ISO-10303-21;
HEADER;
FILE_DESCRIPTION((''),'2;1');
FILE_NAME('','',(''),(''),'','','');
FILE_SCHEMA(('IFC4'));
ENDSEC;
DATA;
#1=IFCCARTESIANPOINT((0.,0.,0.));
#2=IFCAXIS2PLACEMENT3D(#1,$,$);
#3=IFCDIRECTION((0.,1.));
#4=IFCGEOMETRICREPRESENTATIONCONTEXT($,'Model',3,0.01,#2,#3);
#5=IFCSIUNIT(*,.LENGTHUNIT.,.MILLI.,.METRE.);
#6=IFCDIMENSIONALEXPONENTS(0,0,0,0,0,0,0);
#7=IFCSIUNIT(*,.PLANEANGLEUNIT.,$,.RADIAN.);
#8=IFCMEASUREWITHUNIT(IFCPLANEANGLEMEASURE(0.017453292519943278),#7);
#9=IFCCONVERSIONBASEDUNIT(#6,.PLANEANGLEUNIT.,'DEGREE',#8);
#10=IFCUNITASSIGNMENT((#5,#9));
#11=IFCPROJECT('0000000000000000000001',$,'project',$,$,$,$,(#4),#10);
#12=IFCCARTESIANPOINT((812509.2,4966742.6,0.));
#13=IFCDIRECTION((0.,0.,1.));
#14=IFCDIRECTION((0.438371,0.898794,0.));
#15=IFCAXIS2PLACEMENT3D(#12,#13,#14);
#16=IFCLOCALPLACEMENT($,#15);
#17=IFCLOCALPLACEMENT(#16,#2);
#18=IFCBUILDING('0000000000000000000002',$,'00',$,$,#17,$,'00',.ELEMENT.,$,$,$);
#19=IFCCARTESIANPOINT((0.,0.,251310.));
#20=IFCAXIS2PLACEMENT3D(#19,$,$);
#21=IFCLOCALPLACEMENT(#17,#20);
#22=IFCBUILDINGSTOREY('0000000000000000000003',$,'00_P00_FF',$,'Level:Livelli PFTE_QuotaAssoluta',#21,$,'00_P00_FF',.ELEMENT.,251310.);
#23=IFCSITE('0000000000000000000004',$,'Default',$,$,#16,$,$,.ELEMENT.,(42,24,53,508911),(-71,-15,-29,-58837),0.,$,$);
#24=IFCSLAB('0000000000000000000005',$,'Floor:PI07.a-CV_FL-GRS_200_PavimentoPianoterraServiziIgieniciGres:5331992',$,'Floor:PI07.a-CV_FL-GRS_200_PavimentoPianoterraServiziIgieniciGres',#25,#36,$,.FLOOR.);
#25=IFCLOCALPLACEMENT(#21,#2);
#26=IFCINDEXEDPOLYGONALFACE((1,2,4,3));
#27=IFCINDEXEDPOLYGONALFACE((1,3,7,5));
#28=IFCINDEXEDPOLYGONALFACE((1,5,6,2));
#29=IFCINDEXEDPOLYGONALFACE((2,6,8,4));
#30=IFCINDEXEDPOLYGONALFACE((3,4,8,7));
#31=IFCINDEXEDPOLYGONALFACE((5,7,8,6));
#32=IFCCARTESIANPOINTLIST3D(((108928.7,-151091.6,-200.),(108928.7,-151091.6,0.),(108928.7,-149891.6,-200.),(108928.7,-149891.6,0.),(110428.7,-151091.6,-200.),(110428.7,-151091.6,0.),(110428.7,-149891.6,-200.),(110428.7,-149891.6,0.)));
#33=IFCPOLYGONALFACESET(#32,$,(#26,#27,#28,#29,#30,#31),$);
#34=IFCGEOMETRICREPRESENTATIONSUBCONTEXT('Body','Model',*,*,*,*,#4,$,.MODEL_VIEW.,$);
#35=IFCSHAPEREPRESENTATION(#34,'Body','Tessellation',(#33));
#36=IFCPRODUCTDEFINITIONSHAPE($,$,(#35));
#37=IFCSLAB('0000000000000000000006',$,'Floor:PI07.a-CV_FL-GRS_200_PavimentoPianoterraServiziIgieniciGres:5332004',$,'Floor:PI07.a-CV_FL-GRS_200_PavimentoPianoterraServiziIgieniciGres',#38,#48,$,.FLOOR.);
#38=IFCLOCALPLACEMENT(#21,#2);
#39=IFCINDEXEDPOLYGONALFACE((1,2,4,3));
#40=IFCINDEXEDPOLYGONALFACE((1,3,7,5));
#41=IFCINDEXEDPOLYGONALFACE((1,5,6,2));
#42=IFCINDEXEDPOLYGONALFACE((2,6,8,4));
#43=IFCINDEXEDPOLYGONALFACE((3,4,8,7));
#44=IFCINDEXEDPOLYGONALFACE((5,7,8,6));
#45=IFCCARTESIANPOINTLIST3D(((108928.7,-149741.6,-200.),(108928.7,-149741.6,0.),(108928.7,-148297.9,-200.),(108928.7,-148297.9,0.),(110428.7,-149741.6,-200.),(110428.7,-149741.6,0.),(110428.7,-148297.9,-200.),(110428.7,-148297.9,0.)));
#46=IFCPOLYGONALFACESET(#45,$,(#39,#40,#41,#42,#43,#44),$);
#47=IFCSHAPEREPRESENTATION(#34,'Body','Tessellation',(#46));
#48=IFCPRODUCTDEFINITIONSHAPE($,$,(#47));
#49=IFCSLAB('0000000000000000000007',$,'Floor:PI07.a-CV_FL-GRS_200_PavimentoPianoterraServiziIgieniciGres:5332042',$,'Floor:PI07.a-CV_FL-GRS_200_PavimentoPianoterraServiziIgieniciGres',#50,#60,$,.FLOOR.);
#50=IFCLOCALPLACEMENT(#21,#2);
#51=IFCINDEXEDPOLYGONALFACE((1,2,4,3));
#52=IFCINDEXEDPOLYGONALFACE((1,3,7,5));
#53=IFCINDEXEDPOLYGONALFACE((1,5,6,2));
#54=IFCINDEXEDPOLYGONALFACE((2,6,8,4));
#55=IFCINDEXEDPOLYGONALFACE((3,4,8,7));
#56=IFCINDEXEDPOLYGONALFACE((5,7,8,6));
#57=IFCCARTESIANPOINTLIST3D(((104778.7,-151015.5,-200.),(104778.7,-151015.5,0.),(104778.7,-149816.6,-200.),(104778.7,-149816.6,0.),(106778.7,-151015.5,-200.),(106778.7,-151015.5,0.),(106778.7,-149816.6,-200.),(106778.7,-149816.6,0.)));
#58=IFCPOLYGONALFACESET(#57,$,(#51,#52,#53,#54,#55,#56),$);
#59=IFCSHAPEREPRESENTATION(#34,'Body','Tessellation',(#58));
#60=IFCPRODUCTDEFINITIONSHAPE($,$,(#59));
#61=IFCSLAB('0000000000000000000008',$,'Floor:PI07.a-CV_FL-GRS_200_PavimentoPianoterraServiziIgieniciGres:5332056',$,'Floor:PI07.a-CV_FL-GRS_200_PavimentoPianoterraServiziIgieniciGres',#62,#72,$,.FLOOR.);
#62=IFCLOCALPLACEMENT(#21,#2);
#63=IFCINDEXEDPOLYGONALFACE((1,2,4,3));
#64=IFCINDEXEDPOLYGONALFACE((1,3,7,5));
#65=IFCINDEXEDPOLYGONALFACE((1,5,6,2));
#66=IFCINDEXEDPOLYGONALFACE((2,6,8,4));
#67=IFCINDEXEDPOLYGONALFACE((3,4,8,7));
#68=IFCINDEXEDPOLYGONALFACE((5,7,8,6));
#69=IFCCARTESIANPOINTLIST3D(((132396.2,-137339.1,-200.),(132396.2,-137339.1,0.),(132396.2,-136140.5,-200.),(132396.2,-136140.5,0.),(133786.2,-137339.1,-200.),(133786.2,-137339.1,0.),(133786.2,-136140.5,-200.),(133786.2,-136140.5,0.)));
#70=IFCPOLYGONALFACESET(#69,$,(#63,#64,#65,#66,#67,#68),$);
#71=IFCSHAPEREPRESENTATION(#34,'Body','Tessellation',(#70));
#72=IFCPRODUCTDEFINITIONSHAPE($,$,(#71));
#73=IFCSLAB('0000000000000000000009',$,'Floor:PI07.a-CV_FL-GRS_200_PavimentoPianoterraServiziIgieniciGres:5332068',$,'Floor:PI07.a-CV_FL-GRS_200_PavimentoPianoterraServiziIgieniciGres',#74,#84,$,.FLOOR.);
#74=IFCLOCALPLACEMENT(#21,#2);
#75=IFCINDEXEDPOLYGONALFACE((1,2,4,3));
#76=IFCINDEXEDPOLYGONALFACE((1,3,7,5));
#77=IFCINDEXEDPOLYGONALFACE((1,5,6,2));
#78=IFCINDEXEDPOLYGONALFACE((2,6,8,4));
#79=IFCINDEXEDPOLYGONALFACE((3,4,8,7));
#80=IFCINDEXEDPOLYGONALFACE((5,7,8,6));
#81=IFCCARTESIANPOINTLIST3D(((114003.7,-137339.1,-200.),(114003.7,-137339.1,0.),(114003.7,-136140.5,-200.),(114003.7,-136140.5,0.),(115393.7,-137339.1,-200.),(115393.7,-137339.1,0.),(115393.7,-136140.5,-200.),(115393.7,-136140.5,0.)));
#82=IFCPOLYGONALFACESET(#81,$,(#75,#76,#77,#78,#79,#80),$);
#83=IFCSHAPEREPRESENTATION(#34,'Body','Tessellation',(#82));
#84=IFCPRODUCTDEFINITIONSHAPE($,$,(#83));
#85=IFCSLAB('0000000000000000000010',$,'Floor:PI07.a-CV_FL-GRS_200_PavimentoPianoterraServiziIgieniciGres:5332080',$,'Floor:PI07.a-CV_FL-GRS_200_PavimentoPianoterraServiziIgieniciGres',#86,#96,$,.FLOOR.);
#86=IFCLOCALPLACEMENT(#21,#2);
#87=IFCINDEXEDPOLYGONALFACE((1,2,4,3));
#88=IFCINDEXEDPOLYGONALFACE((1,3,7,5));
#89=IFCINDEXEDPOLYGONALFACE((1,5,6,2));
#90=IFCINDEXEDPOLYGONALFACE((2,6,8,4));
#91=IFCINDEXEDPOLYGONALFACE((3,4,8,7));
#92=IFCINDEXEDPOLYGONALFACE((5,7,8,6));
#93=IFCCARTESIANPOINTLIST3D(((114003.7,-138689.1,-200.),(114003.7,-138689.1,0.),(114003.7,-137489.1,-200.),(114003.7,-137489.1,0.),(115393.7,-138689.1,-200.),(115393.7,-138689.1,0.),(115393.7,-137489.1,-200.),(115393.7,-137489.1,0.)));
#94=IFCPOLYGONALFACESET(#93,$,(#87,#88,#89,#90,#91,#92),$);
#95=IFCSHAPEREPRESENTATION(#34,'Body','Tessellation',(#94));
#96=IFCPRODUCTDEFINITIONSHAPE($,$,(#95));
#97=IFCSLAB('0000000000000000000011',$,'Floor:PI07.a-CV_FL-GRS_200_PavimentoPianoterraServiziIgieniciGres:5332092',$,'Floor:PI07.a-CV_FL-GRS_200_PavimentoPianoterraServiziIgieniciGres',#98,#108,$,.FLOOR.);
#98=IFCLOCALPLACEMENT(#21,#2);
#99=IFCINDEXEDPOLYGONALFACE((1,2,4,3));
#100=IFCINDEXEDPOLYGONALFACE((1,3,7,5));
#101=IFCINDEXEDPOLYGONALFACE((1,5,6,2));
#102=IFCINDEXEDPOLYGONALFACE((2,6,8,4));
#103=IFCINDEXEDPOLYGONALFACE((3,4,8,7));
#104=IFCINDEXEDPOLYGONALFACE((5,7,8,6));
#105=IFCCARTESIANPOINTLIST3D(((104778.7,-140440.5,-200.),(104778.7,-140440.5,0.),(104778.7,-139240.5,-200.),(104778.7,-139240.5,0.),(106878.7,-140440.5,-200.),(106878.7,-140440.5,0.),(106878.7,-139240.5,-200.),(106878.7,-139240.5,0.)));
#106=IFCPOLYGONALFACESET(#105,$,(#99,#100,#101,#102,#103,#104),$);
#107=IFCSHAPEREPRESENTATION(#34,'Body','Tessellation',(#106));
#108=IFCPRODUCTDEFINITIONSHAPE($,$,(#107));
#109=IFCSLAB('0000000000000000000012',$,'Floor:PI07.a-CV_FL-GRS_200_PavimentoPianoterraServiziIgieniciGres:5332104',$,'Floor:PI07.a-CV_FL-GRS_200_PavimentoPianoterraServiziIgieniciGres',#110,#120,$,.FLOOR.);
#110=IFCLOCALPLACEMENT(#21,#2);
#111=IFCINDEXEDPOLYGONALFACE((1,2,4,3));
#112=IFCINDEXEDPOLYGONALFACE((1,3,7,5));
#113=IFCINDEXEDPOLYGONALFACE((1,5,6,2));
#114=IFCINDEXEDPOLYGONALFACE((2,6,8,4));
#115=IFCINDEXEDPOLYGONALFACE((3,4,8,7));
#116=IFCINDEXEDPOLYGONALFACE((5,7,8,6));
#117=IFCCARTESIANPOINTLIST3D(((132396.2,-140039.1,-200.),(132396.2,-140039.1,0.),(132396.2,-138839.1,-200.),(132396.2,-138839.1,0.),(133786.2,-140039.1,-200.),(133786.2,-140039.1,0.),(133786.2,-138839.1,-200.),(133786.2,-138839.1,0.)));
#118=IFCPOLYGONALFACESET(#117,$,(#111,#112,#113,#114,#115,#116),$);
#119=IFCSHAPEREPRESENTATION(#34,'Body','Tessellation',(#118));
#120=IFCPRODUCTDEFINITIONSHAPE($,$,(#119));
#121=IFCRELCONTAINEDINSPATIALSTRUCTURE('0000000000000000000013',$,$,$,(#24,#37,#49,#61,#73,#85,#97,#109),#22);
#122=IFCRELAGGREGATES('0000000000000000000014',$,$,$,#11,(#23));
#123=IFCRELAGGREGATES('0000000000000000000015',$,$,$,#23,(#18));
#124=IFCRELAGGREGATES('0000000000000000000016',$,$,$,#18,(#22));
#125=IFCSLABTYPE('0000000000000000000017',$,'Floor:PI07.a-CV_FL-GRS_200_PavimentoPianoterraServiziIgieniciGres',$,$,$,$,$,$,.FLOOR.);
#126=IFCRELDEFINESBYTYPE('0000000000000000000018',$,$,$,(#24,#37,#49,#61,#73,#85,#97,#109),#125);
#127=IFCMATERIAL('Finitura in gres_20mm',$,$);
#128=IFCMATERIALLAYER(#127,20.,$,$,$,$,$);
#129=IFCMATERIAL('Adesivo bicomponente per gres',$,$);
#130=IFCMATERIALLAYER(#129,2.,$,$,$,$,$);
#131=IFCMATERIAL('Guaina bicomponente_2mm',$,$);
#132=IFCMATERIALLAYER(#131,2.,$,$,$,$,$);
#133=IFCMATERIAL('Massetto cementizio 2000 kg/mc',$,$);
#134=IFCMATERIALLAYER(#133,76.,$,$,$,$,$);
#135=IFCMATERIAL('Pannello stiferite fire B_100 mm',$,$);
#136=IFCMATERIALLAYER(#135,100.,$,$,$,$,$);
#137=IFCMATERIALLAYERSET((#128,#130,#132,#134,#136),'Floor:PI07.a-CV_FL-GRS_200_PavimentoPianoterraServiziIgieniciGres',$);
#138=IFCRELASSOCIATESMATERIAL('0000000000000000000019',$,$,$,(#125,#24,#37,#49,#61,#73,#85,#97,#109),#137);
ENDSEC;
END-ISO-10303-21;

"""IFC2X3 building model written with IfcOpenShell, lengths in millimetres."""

from ifc_helpers import new_model, entity, si_unit, converted_unit, direction, frame, frame_2d, origin, origin_2d_with_axis, place, context, subcontext, project, spatial, rectangle, extrude, material, layer, layer_set, layer_usage, type_object, element, save


model = new_model("IFC2X3")

# Units and contexts
model_context = context("Model", 3, precision=0.01, world=origin(), true_north=direction((0.0, 1.0)))
body_context = subcontext(model_context, "Body", "Model", "MODEL_VIEW")
ifc_project = project(units=[si_unit("LENGTHUNIT", "METRE", prefix="MILLI"), converted_unit("PLANEANGLEUNIT", "DEGREE", entity("IfcPlaneAngleMeasure", 0.017453292519943278), si_unit("PLANEANGLEUNIT", "RADIAN"), dimensions=[0, 0, 0, 0, 0, 0, 0])], contexts=[model_context])

# Site, building, storey
site_placement = place(None, frame((812509.2, 4966742.6, 0.0), z_axis=(0.0, 0.0, 1.0), x_axis=(0.438371, 0.898794, 0.0)))
site = spatial("IfcSite", under=ifc_project, at=site_placement, Name="Default", CompositionType="ELEMENT", RefLatitude=(42, 24, 53, 508911), RefLongitude=(-71, -15, -29, -58837), RefElevation=0.0)
building_placement = place(site_placement, origin())
building = spatial("IfcBuilding", under=site, at=building_placement, Name="00", LongName="00", CompositionType="ELEMENT")
storey_placement = place(building_placement, frame((0.0, 0.0, 251310.0)))
storey = spatial("IfcBuildingStorey", under=building, at=storey_placement, Name="00_P00_FF", ObjectType="Level:Livelli PFTE_QuotaAssoluta", LongName="00_P00_FF", CompositionType="ELEMENT", Elevation=251310.0)

# Slabs
ifc_material_1 = material(Name="Pannello stiferite fire B_100 mm")
ifc_material_2 = material(Name="Massetto cementizio 2000 kg/mc")
ifc_material_3 = material(Name="Finitura in gres_20mm")
ifc_layer_1 = layer(ifc_material_3, 20.0)
ifc_material_4 = material(Name="Adesivo bicomponente per gres")
ifc_layer_2 = layer(ifc_material_4, 2.0)
ifc_material_5 = material(Name="Guaina bicomponente_2mm")
ifc_layer_3 = layer(ifc_material_5, 2.0)
ifc_layer_4 = layer(ifc_material_2, 76.0)
ifc_layer_5 = layer(ifc_material_1, 100.0)
ifc_layer_set_1 = layer_set([ifc_layer_1, ifc_layer_2, ifc_layer_3, ifc_layer_4, ifc_layer_5], Name="Floor:PI07.a-CV_FL-GRS_200_PavimentoPianoterraServiziIgieniciGres")
slab_type_1 = type_object("IfcSlabType", Name="Floor:PI07.a-CV_FL-GRS_200_PavimentoPianoterraServiziIgieniciGres", PredefinedType="FLOOR", material=ifc_layer_set_1)
ifc_layer_usage_1 = layer_usage(ifc_layer_set_1, "AXIS3", "POSITIVE", 0.0)
slab_1_placement = place(storey_placement, origin())
element("IfcSlab", 1, at=slab_1_placement, inside=storey, type_object=slab_type_1, material=ifc_layer_usage_1, Name="Floor:PI07.a-CV_FL-GRS_200_PavimentoPianoterraServiziIgieniciGres:5331992", ObjectType="Floor:PI07.a-CV_FL-GRS_200_PavimentoPianoterraServiziIgieniciGres", PredefinedType="FLOOR", context=body_context, shape_type="SweptSolid", body=[
    extrude(rectangle(XDim=1200.0, YDim=1500.0, at=origin_2d_with_axis()), frame((109678.7, -150491.6, 0.0), z_axis=(0.0, 0.0, -1.0), x_axis=(0.0, 1.0, 0.0)), (0.0, 0.0, 1.0), 200.0),
])
ifc_layer_usage_2 = layer_usage(ifc_layer_set_1, "AXIS3", "POSITIVE", 0.0)
slab_2_placement = place(storey_placement, origin())
element("IfcSlab", 2, at=slab_2_placement, inside=storey, type_object=slab_type_1, material=ifc_layer_usage_2, Name="Floor:PI07.a-CV_FL-GRS_200_PavimentoPianoterraServiziIgieniciGres:5332004", ObjectType="Floor:PI07.a-CV_FL-GRS_200_PavimentoPianoterraServiziIgieniciGres", PredefinedType="FLOOR", context=body_context, shape_type="SweptSolid", body=[
    extrude(rectangle(XDim=1443.7, YDim=1500.0, at=origin_2d_with_axis()), frame((109678.7, -149019.8, 0.0), z_axis=(0.0, 0.0, -1.0), x_axis=(0.0, 1.0, 0.0)), (0.0, 0.0, 1.0), 200.0),
])
ifc_layer_usage_3 = layer_usage(ifc_layer_set_1, "AXIS3", "POSITIVE", 0.0)
slab_3_placement = place(storey_placement, origin())
element("IfcSlab", 3, at=slab_3_placement, inside=storey, type_object=slab_type_1, material=ifc_layer_usage_3, Name="Floor:PI07.a-CV_FL-GRS_200_PavimentoPianoterraServiziIgieniciGres:5332042", ObjectType="Floor:PI07.a-CV_FL-GRS_200_PavimentoPianoterraServiziIgieniciGres", PredefinedType="FLOOR", context=body_context, shape_type="SweptSolid", body=[
    extrude(rectangle(XDim=1198.8, YDim=2000.0, at=frame_2d((0.0, 0.0), x_axis=(1.0, 0.0))), frame((105778.7, -150416.1, 0.0), z_axis=(0.0, 0.0, -1.0), x_axis=(0.0, 1.0, 0.0)), (0.0, 0.0, 1.0), 200.0),
])
ifc_layer_usage_4 = layer_usage(ifc_layer_set_1, "AXIS3", "POSITIVE", 0.0)
slab_4_placement = place(storey_placement, origin())
element("IfcSlab", 4, at=slab_4_placement, inside=storey, type_object=slab_type_1, material=ifc_layer_usage_4, Name="Floor:PI07.a-CV_FL-GRS_200_PavimentoPianoterraServiziIgieniciGres:5332056", ObjectType="Floor:PI07.a-CV_FL-GRS_200_PavimentoPianoterraServiziIgieniciGres", PredefinedType="FLOOR", context=body_context, shape_type="SweptSolid", body=[
    extrude(rectangle(XDim=1198.7, YDim=1390.0, at=frame_2d((0.0, 0.0), x_axis=(1.0, 0.0))), frame((133091.2, -136739.8, 0.0), z_axis=(0.0, 0.0, -1.0), x_axis=(0.0, 1.0, 0.0)), (0.0, 0.0, 1.0), 200.0),
])
ifc_layer_usage_5 = layer_usage(ifc_layer_set_1, "AXIS3", "POSITIVE", 0.0)
slab_5_placement = place(storey_placement, origin())
element("IfcSlab", 5, at=slab_5_placement, inside=storey, type_object=slab_type_1, material=ifc_layer_usage_5, Name="Floor:PI07.a-CV_FL-GRS_200_PavimentoPianoterraServiziIgieniciGres:5332068", ObjectType="Floor:PI07.a-CV_FL-GRS_200_PavimentoPianoterraServiziIgieniciGres", PredefinedType="FLOOR", context=body_context, shape_type="SweptSolid", body=[
    extrude(rectangle(XDim=1198.7, YDim=1390.0, at=frame_2d((0.0, 0.0), x_axis=(1.0, 0.0))), frame((114698.7, -136739.8, 0.0), z_axis=(0.0, 0.0, -1.0), x_axis=(0.0, 1.0, 0.0)), (0.0, 0.0, 1.0), 200.0),
])
ifc_layer_usage_6 = layer_usage(ifc_layer_set_1, "AXIS3", "POSITIVE", 0.0)
slab_6_placement = place(storey_placement, origin())
element("IfcSlab", 6, at=slab_6_placement, inside=storey, type_object=slab_type_1, material=ifc_layer_usage_6, Name="Floor:PI07.a-CV_FL-GRS_200_PavimentoPianoterraServiziIgieniciGres:5332080", ObjectType="Floor:PI07.a-CV_FL-GRS_200_PavimentoPianoterraServiziIgieniciGres", PredefinedType="FLOOR", context=body_context, shape_type="SweptSolid", body=[
    extrude(rectangle(XDim=1200.0, YDim=1390.0, at=frame_2d((0.0, 0.0), x_axis=(1.0, 0.0))), frame((114698.7, -138089.1, 0.0), z_axis=(0.0, 0.0, -1.0), x_axis=(0.0, 1.0, 0.0)), (0.0, 0.0, 1.0), 200.0),
])
ifc_layer_usage_7 = layer_usage(ifc_layer_set_1, "AXIS3", "POSITIVE", 0.0)
slab_7_placement = place(storey_placement, origin())
element("IfcSlab", 7, at=slab_7_placement, inside=storey, type_object=slab_type_1, material=ifc_layer_usage_7, Name="Floor:PI07.a-CV_FL-GRS_200_PavimentoPianoterraServiziIgieniciGres:5332092", ObjectType="Floor:PI07.a-CV_FL-GRS_200_PavimentoPianoterraServiziIgieniciGres", PredefinedType="FLOOR", context=body_context, shape_type="SweptSolid", body=[
    extrude(rectangle(XDim=1200.0, YDim=2100.0, at=origin_2d_with_axis()), frame((105828.7, -139840.5, 0.0), z_axis=(0.0, 0.0, -1.0), x_axis=(0.0, 1.0, 0.0)), (0.0, 0.0, 1.0), 200.0),
])
ifc_layer_usage_8 = layer_usage(ifc_layer_set_1, "AXIS3", "POSITIVE", 0.0)
slab_8_placement = place(storey_placement, origin())
element("IfcSlab", 8, at=slab_8_placement, inside=storey, type_object=slab_type_1, material=ifc_layer_usage_8, Name="Floor:PI07.a-CV_FL-GRS_200_PavimentoPianoterraServiziIgieniciGres:5332104", ObjectType="Floor:PI07.a-CV_FL-GRS_200_PavimentoPianoterraServiziIgieniciGres", PredefinedType="FLOOR", context=body_context, shape_type="SweptSolid", body=[
    extrude(rectangle(XDim=1200.0, YDim=1390.0, at=frame_2d((0.0, 0.0), x_axis=(1.0, 0.0))), frame((133091.2, -139439.1, 0.0), z_axis=(0.0, 0.0, -1.0), x_axis=(0.0, 1.0, 0.0)), (0.0, 0.0, 1.0), 200.0),
])

save(model, "model.ifc")
